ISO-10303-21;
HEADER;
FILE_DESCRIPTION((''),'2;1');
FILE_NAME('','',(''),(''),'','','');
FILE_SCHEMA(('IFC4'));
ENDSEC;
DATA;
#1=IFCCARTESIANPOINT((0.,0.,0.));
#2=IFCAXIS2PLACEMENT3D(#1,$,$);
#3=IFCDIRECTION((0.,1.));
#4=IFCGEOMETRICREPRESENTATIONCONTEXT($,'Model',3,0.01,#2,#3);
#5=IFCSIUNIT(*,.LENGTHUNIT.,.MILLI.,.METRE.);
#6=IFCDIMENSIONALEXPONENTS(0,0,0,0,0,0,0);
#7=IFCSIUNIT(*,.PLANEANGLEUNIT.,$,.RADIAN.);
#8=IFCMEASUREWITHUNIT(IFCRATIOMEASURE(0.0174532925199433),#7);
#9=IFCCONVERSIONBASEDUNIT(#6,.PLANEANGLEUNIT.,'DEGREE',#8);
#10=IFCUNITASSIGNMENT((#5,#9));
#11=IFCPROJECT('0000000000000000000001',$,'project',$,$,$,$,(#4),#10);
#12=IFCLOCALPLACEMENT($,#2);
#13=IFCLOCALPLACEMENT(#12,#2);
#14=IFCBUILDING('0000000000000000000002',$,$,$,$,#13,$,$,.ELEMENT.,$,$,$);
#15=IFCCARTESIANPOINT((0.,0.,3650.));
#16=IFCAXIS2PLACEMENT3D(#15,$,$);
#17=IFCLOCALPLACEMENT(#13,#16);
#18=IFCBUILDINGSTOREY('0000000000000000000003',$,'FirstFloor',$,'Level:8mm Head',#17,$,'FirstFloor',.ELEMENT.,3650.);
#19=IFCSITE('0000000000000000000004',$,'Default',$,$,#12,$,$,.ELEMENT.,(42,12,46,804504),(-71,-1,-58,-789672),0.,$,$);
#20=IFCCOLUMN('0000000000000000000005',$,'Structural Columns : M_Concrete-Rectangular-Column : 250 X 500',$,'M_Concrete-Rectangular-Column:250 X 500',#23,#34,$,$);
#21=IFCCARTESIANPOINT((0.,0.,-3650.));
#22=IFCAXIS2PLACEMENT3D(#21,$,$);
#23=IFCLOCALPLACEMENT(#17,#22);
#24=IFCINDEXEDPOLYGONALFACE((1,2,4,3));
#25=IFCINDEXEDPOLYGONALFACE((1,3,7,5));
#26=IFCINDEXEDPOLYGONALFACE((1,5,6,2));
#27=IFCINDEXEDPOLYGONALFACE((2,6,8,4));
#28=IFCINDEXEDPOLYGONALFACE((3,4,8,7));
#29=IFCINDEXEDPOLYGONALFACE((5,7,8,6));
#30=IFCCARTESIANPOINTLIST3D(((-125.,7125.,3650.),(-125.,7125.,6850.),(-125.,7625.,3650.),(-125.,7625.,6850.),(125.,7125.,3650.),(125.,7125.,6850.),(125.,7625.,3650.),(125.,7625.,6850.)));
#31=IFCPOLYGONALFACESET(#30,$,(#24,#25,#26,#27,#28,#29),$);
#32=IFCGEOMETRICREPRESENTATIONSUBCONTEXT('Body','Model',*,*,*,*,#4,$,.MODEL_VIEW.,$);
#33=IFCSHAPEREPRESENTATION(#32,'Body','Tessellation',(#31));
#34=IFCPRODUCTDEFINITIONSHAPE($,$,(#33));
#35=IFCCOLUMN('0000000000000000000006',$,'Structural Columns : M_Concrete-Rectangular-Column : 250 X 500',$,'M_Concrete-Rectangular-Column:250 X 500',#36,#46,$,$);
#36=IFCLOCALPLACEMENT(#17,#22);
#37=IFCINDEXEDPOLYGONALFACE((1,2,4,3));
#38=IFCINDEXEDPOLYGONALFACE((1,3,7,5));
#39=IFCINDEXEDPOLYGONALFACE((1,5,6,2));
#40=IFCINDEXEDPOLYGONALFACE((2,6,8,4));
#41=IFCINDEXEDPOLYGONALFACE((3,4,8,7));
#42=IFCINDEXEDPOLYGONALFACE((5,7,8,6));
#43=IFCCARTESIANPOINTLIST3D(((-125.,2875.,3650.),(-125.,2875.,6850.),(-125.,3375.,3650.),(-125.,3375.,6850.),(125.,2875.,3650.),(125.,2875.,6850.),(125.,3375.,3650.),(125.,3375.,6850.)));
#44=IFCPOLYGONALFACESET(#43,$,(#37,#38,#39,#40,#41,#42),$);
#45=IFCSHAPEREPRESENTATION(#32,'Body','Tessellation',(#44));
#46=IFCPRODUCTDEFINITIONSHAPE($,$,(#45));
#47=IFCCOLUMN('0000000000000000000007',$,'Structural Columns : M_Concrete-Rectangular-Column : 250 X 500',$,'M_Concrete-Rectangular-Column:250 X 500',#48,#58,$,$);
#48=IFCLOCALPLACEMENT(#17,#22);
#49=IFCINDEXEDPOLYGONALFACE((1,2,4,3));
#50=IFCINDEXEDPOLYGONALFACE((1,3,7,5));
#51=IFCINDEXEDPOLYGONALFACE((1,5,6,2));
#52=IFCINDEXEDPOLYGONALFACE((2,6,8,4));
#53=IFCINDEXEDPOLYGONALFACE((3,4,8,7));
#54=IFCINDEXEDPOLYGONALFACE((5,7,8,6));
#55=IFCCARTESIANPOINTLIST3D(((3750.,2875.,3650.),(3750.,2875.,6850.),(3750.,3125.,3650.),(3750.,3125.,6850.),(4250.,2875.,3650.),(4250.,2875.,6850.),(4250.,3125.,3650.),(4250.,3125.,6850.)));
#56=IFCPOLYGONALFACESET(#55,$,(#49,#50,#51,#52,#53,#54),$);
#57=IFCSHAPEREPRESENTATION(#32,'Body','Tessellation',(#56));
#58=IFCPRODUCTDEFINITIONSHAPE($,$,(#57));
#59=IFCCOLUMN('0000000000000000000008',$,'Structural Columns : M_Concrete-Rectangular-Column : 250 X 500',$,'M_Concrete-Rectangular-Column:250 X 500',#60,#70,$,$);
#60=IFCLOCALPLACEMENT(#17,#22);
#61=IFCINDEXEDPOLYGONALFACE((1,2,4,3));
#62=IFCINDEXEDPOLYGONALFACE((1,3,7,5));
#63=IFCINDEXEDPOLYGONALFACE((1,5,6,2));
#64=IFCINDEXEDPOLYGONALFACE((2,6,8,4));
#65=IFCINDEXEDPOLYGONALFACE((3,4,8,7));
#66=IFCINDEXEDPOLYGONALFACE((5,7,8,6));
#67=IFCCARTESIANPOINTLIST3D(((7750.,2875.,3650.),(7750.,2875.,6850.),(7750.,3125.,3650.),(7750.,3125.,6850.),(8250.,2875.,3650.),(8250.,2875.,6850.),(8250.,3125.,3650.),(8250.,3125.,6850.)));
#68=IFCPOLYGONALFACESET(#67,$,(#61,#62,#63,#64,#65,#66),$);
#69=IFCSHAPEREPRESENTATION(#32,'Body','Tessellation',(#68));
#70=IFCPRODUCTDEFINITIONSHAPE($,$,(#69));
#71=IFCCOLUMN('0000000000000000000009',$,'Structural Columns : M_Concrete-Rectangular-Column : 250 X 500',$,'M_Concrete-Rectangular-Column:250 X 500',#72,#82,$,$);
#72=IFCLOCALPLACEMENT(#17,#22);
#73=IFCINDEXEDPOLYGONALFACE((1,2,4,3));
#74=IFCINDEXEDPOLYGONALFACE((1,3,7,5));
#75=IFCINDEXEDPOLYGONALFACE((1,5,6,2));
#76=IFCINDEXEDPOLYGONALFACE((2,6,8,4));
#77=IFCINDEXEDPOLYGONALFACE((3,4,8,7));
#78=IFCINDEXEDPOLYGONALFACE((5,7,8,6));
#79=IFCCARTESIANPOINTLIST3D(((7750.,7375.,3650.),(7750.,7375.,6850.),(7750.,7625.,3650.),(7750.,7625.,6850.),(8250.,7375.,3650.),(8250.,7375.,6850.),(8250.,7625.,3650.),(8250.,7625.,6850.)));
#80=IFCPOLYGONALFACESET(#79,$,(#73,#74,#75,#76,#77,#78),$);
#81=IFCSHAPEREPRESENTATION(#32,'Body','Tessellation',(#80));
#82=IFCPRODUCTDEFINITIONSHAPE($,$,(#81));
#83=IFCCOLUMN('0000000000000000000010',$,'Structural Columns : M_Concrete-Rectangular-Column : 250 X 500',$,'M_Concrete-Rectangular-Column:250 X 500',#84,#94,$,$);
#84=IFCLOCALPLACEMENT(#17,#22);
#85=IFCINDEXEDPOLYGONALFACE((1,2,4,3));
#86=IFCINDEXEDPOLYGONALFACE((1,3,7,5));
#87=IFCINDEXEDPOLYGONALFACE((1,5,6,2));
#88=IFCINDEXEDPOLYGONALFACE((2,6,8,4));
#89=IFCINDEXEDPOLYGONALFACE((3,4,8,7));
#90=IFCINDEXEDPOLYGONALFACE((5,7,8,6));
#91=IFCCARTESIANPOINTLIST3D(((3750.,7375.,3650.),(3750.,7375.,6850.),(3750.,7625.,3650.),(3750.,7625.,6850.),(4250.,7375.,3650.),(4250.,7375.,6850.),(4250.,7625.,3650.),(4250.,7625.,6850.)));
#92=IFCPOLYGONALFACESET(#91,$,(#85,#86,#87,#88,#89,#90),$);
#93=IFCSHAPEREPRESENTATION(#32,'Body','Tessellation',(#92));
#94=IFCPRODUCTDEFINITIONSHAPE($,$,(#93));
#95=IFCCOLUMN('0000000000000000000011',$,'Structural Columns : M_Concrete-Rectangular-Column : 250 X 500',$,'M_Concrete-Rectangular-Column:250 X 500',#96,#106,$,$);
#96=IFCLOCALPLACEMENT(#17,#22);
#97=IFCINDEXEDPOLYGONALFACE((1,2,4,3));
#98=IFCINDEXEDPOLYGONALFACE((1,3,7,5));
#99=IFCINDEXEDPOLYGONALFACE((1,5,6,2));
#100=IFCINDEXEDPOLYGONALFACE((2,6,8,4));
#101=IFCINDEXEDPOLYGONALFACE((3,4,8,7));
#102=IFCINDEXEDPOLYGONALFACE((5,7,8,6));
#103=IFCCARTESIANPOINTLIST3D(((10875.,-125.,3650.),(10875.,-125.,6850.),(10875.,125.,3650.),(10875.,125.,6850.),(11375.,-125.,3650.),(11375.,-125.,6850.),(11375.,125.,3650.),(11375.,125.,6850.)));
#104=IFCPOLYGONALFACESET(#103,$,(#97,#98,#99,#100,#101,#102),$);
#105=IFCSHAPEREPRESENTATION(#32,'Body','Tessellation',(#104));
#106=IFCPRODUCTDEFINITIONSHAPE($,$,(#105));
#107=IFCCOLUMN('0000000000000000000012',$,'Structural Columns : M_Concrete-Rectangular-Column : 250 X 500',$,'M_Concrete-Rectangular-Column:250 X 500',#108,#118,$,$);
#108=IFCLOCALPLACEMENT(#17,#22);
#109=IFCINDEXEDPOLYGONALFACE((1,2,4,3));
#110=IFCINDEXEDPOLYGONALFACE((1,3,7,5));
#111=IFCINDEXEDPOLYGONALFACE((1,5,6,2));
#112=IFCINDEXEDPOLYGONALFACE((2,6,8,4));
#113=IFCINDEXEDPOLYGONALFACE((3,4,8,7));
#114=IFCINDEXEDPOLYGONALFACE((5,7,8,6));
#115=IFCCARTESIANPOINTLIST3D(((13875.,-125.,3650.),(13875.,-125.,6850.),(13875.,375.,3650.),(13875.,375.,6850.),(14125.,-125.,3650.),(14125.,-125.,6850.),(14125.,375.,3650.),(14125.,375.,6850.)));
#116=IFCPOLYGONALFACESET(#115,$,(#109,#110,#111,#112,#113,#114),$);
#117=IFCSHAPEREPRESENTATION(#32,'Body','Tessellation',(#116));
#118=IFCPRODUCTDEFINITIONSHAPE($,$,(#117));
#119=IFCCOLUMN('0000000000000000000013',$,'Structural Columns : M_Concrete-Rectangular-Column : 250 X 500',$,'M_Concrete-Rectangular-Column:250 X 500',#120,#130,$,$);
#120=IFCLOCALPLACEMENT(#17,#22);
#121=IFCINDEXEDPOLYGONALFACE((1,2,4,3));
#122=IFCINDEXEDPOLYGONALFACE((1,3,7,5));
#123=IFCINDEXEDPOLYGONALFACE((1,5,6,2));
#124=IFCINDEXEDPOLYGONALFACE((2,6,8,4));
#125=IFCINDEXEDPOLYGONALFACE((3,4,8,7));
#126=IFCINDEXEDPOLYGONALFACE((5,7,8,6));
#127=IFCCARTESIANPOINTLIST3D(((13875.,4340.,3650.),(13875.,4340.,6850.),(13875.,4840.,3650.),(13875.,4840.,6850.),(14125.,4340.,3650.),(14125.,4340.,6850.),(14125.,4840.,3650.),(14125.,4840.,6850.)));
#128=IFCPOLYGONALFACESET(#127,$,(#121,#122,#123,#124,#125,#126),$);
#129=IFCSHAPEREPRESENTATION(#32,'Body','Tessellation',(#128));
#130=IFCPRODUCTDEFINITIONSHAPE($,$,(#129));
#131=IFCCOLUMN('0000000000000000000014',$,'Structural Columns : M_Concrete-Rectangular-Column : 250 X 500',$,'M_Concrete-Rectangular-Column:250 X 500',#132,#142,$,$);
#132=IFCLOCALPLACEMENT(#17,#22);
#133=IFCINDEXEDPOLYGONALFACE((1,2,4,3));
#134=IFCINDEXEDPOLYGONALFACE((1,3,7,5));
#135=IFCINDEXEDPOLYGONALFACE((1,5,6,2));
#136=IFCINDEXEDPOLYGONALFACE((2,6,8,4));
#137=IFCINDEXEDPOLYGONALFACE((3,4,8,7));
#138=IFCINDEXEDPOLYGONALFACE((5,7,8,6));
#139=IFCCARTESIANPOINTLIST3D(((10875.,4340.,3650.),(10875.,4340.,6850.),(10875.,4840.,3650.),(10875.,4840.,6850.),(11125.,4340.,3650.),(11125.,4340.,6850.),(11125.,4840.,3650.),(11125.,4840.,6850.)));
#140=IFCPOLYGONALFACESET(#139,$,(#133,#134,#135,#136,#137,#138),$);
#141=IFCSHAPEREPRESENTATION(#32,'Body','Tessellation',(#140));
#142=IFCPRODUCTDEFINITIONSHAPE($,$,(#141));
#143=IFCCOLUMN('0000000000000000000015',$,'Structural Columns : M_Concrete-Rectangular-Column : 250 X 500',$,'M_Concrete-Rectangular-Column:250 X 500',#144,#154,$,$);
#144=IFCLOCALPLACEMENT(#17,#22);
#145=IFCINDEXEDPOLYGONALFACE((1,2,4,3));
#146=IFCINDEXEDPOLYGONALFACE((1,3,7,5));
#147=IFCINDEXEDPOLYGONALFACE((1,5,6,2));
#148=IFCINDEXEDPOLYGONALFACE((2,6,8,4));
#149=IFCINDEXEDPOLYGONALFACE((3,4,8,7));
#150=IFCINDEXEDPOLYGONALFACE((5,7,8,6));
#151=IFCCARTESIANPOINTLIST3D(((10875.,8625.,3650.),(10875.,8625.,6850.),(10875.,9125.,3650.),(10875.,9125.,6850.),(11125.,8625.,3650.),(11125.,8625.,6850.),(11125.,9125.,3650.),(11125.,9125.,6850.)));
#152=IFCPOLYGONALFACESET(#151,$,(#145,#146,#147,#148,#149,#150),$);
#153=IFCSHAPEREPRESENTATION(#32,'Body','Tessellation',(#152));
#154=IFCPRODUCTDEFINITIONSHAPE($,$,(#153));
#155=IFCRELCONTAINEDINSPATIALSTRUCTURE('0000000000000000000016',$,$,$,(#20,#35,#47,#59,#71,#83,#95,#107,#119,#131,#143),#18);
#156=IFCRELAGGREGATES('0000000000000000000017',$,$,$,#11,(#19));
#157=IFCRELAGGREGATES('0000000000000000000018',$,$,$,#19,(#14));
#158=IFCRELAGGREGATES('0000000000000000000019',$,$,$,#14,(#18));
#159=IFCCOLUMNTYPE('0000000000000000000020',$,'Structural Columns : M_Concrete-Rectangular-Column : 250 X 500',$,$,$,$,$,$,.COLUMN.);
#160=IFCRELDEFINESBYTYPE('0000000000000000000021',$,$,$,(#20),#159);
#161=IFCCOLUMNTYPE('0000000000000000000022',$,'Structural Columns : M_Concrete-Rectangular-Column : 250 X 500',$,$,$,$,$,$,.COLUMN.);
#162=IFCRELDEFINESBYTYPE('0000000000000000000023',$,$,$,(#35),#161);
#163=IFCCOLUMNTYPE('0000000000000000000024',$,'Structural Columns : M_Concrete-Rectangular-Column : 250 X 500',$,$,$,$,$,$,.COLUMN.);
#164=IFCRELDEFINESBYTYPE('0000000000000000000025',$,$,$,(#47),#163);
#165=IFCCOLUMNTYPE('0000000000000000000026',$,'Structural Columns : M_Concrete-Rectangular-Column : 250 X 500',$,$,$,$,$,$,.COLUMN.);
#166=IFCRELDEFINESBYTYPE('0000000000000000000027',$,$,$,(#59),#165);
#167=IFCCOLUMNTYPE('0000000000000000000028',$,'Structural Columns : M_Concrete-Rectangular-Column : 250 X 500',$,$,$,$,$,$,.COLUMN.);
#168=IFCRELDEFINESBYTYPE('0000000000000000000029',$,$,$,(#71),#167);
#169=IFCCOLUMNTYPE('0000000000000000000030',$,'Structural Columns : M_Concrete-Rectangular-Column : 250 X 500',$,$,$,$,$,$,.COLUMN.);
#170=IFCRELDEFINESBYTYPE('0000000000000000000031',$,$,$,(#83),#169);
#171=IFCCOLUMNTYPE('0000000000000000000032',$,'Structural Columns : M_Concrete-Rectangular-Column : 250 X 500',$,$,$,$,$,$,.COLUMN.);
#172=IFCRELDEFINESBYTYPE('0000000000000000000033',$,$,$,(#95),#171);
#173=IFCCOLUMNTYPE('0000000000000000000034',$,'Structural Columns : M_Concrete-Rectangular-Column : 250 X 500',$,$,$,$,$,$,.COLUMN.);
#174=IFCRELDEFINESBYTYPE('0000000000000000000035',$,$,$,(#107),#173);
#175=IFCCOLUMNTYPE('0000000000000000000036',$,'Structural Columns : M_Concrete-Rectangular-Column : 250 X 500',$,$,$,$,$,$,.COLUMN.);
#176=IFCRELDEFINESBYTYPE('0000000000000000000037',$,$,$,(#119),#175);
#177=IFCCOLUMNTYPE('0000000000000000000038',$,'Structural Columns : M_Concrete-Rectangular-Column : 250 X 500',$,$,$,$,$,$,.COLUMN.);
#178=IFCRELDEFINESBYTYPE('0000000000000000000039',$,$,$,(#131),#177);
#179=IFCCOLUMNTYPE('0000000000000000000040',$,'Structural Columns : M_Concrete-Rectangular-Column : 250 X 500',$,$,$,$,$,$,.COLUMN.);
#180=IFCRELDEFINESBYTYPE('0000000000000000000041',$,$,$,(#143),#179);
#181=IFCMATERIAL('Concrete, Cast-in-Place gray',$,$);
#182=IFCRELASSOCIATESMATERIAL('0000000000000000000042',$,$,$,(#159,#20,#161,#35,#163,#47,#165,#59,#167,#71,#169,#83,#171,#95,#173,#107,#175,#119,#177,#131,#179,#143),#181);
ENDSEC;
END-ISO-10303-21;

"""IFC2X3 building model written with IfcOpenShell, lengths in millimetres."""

from ifc_helpers import new_model, entity, si_unit, converted_unit, direction, frame, frame_2d, origin, origin_2d_with_axis, place, context, subcontext, project, spatial, rectangle, extrude, source, transform, mapped, material, type_object, type_shapes, element, save


model = new_model("IFC2X3")

# Units and contexts
model_context = context("Model", 3, precision=0.01, world=origin(), true_north=direction((0.0, 1.0)))
body_context = subcontext(model_context, "Body", "Model", "MODEL_VIEW")
ifc_project = project(units=[si_unit("LENGTHUNIT", "METRE", prefix="MILLI"), converted_unit("PLANEANGLEUNIT", "DEGREE", entity("IfcRatioMeasure", 0.0174532925199433), si_unit("PLANEANGLEUNIT", "RADIAN"), dimensions=[0, 0, 0, 0, 0, 0, 0])], contexts=[model_context])

# Site, building, storey
site_placement = place(None, origin())
site = spatial("IfcSite", under=ifc_project, at=site_placement, Name="Default", CompositionType="ELEMENT", RefLatitude=(42, 12, 46, 804504), RefLongitude=(-71, -1, -58, -789672), RefElevation=0.0)
building_placement = place(site_placement, origin())
building = spatial("IfcBuilding", under=site, at=building_placement, CompositionType="ELEMENT")
storey_placement = place(building_placement, frame((0.0, 0.0, 3650.0)))
storey = spatial("IfcBuildingStorey", under=building, at=storey_placement, Name="FirstFloor", ObjectType="Level:8mm Head", LongName="FirstFloor", CompositionType="ELEMENT", Elevation=3650.0)

# Columns
ifc_material = material(Name="Concrete, Cast-in-Place gray")
column_type_1 = type_object("IfcColumnType", Name="Structural Columns : M_Concrete-Rectangular-Column : 250 X 500", PredefinedType="COLUMN", material=ifc_material)
shared_shape_1 = source(origin(), body_context, "Body", "SweptSolid", [
    extrude(rectangle(XDim=500.0, YDim=250.0, at=frame_2d((0.0, 0.0), x_axis=(1.0, 0.0))), frame((0.0, 7375.0, 3650.0), z_axis=(0.0, 0.0, 1.0), x_axis=(0.0, -1.0, 0.0)), (0.0, 0.0, 1.0), 3200.0),
])
type_shapes(column_type_1, [shared_shape_1])
column_1_placement = place(storey_placement, frame((0.0, 0.0, -3650.0)))
element("IfcColumn", 1, at=column_1_placement, inside=storey, type_object=column_type_1, material=ifc_material, Name="Structural Columns : M_Concrete-Rectangular-Column : 250 X 500", ObjectType="M_Concrete-Rectangular-Column:250 X 500", context=body_context, shape_type="MappedRepresentation", body=[
    mapped(shared_shape_1, transform((0.0, 0.0, 0.0), scale=1.0)),
])
column_type_2 = type_object("IfcColumnType", Name="Structural Columns : M_Concrete-Rectangular-Column : 250 X 500", PredefinedType="COLUMN", material=ifc_material)
shared_shape_2 = source(origin(), body_context, "Body", "SweptSolid", [
    extrude(rectangle(XDim=500.0, YDim=250.0, at=origin_2d_with_axis()), frame((0.0, 3125.0, 3650.0), z_axis=(0.0, 0.0, 1.0), x_axis=(0.0, -1.0, 0.0)), (0.0, 0.0, 1.0), 3200.0),
])
type_shapes(column_type_2, [shared_shape_2])
column_2_placement = place(storey_placement, frame((0.0, 0.0, -3650.0)))
element("IfcColumn", 2, at=column_2_placement, inside=storey, type_object=column_type_2, material=ifc_material, Name="Structural Columns : M_Concrete-Rectangular-Column : 250 X 500", ObjectType="M_Concrete-Rectangular-Column:250 X 500", context=body_context, shape_type="MappedRepresentation", body=[
    mapped(shared_shape_2, transform((0.0, 0.0, 0.0), scale=1.0)),
])
column_type_3 = type_object("IfcColumnType", Name="Structural Columns : M_Concrete-Rectangular-Column : 250 X 500", PredefinedType="COLUMN", material=ifc_material)
shared_shape_3 = source(origin(), body_context, "Body", "SweptSolid", [
    extrude(rectangle(XDim=250.0, YDim=500.0, at=frame_2d((0.0, 0.0), x_axis=(1.0, 0.0))), frame((4000.0, 3000.0, 3650.0), z_axis=(0.0, 0.0, 1.0), x_axis=(0.0, -1.0, 0.0)), (0.0, 0.0, 1.0), 3200.0),
])
type_shapes(column_type_3, [shared_shape_3])
column_3_placement = place(storey_placement, frame((0.0, 0.0, -3650.0)))
element("IfcColumn", 3, at=column_3_placement, inside=storey, type_object=column_type_3, material=ifc_material, Name="Structural Columns : M_Concrete-Rectangular-Column : 250 X 500", ObjectType="M_Concrete-Rectangular-Column:250 X 500", context=body_context, shape_type="MappedRepresentation", body=[
    mapped(shared_shape_3, transform((0.0, 0.0, 0.0), scale=1.0)),
])
column_type_4 = type_object("IfcColumnType", Name="Structural Columns : M_Concrete-Rectangular-Column : 250 X 500", PredefinedType="COLUMN", material=ifc_material)
shared_shape_4 = source(origin(), body_context, "Body", "SweptSolid", [
    extrude(rectangle(XDim=250.0, YDim=500.0, at=frame_2d((0.0, 0.0), x_axis=(1.0, 0.0))), frame((8000.0, 3000.0, 3650.0), z_axis=(0.0, 0.0, 1.0), x_axis=(0.0, -1.0, 0.0)), (0.0, 0.0, 1.0), 3200.0),
])
type_shapes(column_type_4, [shared_shape_4])
column_4_placement = place(storey_placement, frame((0.0, 0.0, -3650.0)))
element("IfcColumn", 4, at=column_4_placement, inside=storey, type_object=column_type_4, material=ifc_material, Name="Structural Columns : M_Concrete-Rectangular-Column : 250 X 500", ObjectType="M_Concrete-Rectangular-Column:250 X 500", context=body_context, shape_type="MappedRepresentation", body=[
    mapped(shared_shape_4, transform((0.0, 0.0, 0.0), scale=1.0)),
])
column_type_5 = type_object("IfcColumnType", Name="Structural Columns : M_Concrete-Rectangular-Column : 250 X 500", PredefinedType="COLUMN", material=ifc_material)
shared_shape_5 = source(origin(), body_context, "Body", "SweptSolid", [
    extrude(rectangle(XDim=250.0, YDim=500.0, at=frame_2d((0.0, 0.0), x_axis=(1.0, 0.0))), frame((8000.0, 7500.0, 3650.0), z_axis=(0.0, 0.0, 1.0), x_axis=(0.0, -1.0, 0.0)), (0.0, 0.0, 1.0), 3200.0),
])
type_shapes(column_type_5, [shared_shape_5])
column_5_placement = place(storey_placement, frame((0.0, 0.0, -3650.0)))
element("IfcColumn", 5, at=column_5_placement, inside=storey, type_object=column_type_5, material=ifc_material, Name="Structural Columns : M_Concrete-Rectangular-Column : 250 X 500", ObjectType="M_Concrete-Rectangular-Column:250 X 500", context=body_context, shape_type="MappedRepresentation", body=[
    mapped(shared_shape_5, transform((0.0, 0.0, 0.0), scale=1.0)),
])
column_type_6 = type_object("IfcColumnType", Name="Structural Columns : M_Concrete-Rectangular-Column : 250 X 500", PredefinedType="COLUMN", material=ifc_material)
shared_shape_6 = source(origin(), body_context, "Body", "SweptSolid", [
    extrude(rectangle(XDim=250.0, YDim=500.0, at=origin_2d_with_axis()), frame((4000.0, 7500.0, 3650.0), z_axis=(0.0, 0.0, 1.0), x_axis=(0.0, -1.0, 0.0)), (0.0, 0.0, 1.0), 3200.0),
])
type_shapes(column_type_6, [shared_shape_6])
column_6_placement = place(storey_placement, frame((0.0, 0.0, -3650.0)))
element("IfcColumn", 6, at=column_6_placement, inside=storey, type_object=column_type_6, material=ifc_material, Name="Structural Columns : M_Concrete-Rectangular-Column : 250 X 500", ObjectType="M_Concrete-Rectangular-Column:250 X 500", context=body_context, shape_type="MappedRepresentation", body=[
    mapped(shared_shape_6, transform((0.0, 0.0, 0.0), scale=1.0)),
])
column_type_7 = type_object("IfcColumnType", Name="Structural Columns : M_Concrete-Rectangular-Column : 250 X 500", PredefinedType="COLUMN", material=ifc_material)
shared_shape_7 = source(origin(), body_context, "Body", "SweptSolid", [
    extrude(rectangle(XDim=250.0, YDim=500.0, at=origin_2d_with_axis()), frame((11125.0, 0.0, 3650.0), z_axis=(0.0, 0.0, 1.0), x_axis=(0.0, -1.0, 0.0)), (0.0, 0.0, 1.0), 3200.0),
])
type_shapes(column_type_7, [shared_shape_7])
column_7_placement = place(storey_placement, frame((0.0, 0.0, -3650.0)))
element("IfcColumn", 7, at=column_7_placement, inside=storey, type_object=column_type_7, material=ifc_material, Name="Structural Columns : M_Concrete-Rectangular-Column : 250 X 500", ObjectType="M_Concrete-Rectangular-Column:250 X 500", context=body_context, shape_type="MappedRepresentation", body=[
    mapped(shared_shape_7, transform((0.0, 0.0, 0.0), scale=1.0)),
])
column_type_8 = type_object("IfcColumnType", Name="Structural Columns : M_Concrete-Rectangular-Column : 250 X 500", PredefinedType="COLUMN", material=ifc_material)
shared_shape_8 = source(origin(), body_context, "Body", "SweptSolid", [
    extrude(rectangle(XDim=500.0, YDim=250.0, at=frame_2d((0.0, 0.0), x_axis=(1.0, 0.0))), frame((14000.0, 125.0, 3650.0), z_axis=(0.0, 0.0, 1.0), x_axis=(0.0, -1.0, 0.0)), (0.0, 0.0, 1.0), 3200.0),
])
type_shapes(column_type_8, [shared_shape_8])
column_8_placement = place(storey_placement, frame((0.0, 0.0, -3650.0)))
element("IfcColumn", 8, at=column_8_placement, inside=storey, type_object=column_type_8, material=ifc_material, Name="Structural Columns : M_Concrete-Rectangular-Column : 250 X 500", ObjectType="M_Concrete-Rectangular-Column:250 X 500", context=body_context, shape_type="MappedRepresentation", body=[
    mapped(shared_shape_8, transform((0.0, 0.0, 0.0), scale=1.0)),
])
column_type_9 = type_object("IfcColumnType", Name="Structural Columns : M_Concrete-Rectangular-Column : 250 X 500", PredefinedType="COLUMN", material=ifc_material)
shared_shape_9 = source(origin(), body_context, "Body", "SweptSolid", [
    extrude(rectangle(XDim=500.0, YDim=250.0, at=origin_2d_with_axis()), frame((14000.0, 4590.0, 3650.0), z_axis=(0.0, 0.0, 1.0), x_axis=(0.0, -1.0, 0.0)), (0.0, 0.0, 1.0), 3200.0),
])
type_shapes(column_type_9, [shared_shape_9])
column_9_placement = place(storey_placement, frame((0.0, 0.0, -3650.0)))
element("IfcColumn", 9, at=column_9_placement, inside=storey, type_object=column_type_9, material=ifc_material, Name="Structural Columns : M_Concrete-Rectangular-Column : 250 X 500", ObjectType="M_Concrete-Rectangular-Column:250 X 500", context=body_context, shape_type="MappedRepresentation", body=[
    mapped(shared_shape_9, transform((0.0, 0.0, 0.0), scale=1.0)),
])
column_type_10 = type_object("IfcColumnType", Name="Structural Columns : M_Concrete-Rectangular-Column : 250 X 500", PredefinedType="COLUMN", material=ifc_material)
shared_shape_10 = source(origin(), body_context, "Body", "SweptSolid", [
    extrude(rectangle(XDim=500.0, YDim=250.0, at=origin_2d_with_axis()), frame((11000.0, 4590.0, 3650.0), z_axis=(0.0, 0.0, 1.0), x_axis=(0.0, -1.0, 0.0)), (0.0, 0.0, 1.0), 3200.0),
])
type_shapes(column_type_10, [shared_shape_10])
column_10_placement = place(storey_placement, frame((0.0, 0.0, -3650.0)))
element("IfcColumn", 10, at=column_10_placement, inside=storey, type_object=column_type_10, material=ifc_material, Name="Structural Columns : M_Concrete-Rectangular-Column : 250 X 500", ObjectType="M_Concrete-Rectangular-Column:250 X 500", context=body_context, shape_type="MappedRepresentation", body=[
    mapped(shared_shape_10, transform((0.0, 0.0, 0.0), scale=1.0)),
])
column_type_11 = type_object("IfcColumnType", Name="Structural Columns : M_Concrete-Rectangular-Column : 250 X 500", PredefinedType="COLUMN", material=ifc_material)
shared_shape_11 = source(origin(), body_context, "Body", "SweptSolid", [
    extrude(rectangle(XDim=500.0, YDim=250.0, at=frame_2d((0.0, 0.0), x_axis=(1.0, 0.0))), frame((11000.0, 8875.0, 3650.0), z_axis=(0.0, 0.0, 1.0), x_axis=(0.0, -1.0, 0.0)), (0.0, 0.0, 1.0), 3200.0),
])
type_shapes(column_type_11, [shared_shape_11])
column_11_placement = place(storey_placement, frame((0.0, 0.0, -3650.0)))
element("IfcColumn", 11, at=column_11_placement, inside=storey, type_object=column_type_11, material=ifc_material, Name="Structural Columns : M_Concrete-Rectangular-Column : 250 X 500", ObjectType="M_Concrete-Rectangular-Column:250 X 500", context=body_context, shape_type="MappedRepresentation", body=[
    mapped(shared_shape_11, transform((0.0, 0.0, 0.0), scale=1.0)),
])

save(model, "model.ifc")
